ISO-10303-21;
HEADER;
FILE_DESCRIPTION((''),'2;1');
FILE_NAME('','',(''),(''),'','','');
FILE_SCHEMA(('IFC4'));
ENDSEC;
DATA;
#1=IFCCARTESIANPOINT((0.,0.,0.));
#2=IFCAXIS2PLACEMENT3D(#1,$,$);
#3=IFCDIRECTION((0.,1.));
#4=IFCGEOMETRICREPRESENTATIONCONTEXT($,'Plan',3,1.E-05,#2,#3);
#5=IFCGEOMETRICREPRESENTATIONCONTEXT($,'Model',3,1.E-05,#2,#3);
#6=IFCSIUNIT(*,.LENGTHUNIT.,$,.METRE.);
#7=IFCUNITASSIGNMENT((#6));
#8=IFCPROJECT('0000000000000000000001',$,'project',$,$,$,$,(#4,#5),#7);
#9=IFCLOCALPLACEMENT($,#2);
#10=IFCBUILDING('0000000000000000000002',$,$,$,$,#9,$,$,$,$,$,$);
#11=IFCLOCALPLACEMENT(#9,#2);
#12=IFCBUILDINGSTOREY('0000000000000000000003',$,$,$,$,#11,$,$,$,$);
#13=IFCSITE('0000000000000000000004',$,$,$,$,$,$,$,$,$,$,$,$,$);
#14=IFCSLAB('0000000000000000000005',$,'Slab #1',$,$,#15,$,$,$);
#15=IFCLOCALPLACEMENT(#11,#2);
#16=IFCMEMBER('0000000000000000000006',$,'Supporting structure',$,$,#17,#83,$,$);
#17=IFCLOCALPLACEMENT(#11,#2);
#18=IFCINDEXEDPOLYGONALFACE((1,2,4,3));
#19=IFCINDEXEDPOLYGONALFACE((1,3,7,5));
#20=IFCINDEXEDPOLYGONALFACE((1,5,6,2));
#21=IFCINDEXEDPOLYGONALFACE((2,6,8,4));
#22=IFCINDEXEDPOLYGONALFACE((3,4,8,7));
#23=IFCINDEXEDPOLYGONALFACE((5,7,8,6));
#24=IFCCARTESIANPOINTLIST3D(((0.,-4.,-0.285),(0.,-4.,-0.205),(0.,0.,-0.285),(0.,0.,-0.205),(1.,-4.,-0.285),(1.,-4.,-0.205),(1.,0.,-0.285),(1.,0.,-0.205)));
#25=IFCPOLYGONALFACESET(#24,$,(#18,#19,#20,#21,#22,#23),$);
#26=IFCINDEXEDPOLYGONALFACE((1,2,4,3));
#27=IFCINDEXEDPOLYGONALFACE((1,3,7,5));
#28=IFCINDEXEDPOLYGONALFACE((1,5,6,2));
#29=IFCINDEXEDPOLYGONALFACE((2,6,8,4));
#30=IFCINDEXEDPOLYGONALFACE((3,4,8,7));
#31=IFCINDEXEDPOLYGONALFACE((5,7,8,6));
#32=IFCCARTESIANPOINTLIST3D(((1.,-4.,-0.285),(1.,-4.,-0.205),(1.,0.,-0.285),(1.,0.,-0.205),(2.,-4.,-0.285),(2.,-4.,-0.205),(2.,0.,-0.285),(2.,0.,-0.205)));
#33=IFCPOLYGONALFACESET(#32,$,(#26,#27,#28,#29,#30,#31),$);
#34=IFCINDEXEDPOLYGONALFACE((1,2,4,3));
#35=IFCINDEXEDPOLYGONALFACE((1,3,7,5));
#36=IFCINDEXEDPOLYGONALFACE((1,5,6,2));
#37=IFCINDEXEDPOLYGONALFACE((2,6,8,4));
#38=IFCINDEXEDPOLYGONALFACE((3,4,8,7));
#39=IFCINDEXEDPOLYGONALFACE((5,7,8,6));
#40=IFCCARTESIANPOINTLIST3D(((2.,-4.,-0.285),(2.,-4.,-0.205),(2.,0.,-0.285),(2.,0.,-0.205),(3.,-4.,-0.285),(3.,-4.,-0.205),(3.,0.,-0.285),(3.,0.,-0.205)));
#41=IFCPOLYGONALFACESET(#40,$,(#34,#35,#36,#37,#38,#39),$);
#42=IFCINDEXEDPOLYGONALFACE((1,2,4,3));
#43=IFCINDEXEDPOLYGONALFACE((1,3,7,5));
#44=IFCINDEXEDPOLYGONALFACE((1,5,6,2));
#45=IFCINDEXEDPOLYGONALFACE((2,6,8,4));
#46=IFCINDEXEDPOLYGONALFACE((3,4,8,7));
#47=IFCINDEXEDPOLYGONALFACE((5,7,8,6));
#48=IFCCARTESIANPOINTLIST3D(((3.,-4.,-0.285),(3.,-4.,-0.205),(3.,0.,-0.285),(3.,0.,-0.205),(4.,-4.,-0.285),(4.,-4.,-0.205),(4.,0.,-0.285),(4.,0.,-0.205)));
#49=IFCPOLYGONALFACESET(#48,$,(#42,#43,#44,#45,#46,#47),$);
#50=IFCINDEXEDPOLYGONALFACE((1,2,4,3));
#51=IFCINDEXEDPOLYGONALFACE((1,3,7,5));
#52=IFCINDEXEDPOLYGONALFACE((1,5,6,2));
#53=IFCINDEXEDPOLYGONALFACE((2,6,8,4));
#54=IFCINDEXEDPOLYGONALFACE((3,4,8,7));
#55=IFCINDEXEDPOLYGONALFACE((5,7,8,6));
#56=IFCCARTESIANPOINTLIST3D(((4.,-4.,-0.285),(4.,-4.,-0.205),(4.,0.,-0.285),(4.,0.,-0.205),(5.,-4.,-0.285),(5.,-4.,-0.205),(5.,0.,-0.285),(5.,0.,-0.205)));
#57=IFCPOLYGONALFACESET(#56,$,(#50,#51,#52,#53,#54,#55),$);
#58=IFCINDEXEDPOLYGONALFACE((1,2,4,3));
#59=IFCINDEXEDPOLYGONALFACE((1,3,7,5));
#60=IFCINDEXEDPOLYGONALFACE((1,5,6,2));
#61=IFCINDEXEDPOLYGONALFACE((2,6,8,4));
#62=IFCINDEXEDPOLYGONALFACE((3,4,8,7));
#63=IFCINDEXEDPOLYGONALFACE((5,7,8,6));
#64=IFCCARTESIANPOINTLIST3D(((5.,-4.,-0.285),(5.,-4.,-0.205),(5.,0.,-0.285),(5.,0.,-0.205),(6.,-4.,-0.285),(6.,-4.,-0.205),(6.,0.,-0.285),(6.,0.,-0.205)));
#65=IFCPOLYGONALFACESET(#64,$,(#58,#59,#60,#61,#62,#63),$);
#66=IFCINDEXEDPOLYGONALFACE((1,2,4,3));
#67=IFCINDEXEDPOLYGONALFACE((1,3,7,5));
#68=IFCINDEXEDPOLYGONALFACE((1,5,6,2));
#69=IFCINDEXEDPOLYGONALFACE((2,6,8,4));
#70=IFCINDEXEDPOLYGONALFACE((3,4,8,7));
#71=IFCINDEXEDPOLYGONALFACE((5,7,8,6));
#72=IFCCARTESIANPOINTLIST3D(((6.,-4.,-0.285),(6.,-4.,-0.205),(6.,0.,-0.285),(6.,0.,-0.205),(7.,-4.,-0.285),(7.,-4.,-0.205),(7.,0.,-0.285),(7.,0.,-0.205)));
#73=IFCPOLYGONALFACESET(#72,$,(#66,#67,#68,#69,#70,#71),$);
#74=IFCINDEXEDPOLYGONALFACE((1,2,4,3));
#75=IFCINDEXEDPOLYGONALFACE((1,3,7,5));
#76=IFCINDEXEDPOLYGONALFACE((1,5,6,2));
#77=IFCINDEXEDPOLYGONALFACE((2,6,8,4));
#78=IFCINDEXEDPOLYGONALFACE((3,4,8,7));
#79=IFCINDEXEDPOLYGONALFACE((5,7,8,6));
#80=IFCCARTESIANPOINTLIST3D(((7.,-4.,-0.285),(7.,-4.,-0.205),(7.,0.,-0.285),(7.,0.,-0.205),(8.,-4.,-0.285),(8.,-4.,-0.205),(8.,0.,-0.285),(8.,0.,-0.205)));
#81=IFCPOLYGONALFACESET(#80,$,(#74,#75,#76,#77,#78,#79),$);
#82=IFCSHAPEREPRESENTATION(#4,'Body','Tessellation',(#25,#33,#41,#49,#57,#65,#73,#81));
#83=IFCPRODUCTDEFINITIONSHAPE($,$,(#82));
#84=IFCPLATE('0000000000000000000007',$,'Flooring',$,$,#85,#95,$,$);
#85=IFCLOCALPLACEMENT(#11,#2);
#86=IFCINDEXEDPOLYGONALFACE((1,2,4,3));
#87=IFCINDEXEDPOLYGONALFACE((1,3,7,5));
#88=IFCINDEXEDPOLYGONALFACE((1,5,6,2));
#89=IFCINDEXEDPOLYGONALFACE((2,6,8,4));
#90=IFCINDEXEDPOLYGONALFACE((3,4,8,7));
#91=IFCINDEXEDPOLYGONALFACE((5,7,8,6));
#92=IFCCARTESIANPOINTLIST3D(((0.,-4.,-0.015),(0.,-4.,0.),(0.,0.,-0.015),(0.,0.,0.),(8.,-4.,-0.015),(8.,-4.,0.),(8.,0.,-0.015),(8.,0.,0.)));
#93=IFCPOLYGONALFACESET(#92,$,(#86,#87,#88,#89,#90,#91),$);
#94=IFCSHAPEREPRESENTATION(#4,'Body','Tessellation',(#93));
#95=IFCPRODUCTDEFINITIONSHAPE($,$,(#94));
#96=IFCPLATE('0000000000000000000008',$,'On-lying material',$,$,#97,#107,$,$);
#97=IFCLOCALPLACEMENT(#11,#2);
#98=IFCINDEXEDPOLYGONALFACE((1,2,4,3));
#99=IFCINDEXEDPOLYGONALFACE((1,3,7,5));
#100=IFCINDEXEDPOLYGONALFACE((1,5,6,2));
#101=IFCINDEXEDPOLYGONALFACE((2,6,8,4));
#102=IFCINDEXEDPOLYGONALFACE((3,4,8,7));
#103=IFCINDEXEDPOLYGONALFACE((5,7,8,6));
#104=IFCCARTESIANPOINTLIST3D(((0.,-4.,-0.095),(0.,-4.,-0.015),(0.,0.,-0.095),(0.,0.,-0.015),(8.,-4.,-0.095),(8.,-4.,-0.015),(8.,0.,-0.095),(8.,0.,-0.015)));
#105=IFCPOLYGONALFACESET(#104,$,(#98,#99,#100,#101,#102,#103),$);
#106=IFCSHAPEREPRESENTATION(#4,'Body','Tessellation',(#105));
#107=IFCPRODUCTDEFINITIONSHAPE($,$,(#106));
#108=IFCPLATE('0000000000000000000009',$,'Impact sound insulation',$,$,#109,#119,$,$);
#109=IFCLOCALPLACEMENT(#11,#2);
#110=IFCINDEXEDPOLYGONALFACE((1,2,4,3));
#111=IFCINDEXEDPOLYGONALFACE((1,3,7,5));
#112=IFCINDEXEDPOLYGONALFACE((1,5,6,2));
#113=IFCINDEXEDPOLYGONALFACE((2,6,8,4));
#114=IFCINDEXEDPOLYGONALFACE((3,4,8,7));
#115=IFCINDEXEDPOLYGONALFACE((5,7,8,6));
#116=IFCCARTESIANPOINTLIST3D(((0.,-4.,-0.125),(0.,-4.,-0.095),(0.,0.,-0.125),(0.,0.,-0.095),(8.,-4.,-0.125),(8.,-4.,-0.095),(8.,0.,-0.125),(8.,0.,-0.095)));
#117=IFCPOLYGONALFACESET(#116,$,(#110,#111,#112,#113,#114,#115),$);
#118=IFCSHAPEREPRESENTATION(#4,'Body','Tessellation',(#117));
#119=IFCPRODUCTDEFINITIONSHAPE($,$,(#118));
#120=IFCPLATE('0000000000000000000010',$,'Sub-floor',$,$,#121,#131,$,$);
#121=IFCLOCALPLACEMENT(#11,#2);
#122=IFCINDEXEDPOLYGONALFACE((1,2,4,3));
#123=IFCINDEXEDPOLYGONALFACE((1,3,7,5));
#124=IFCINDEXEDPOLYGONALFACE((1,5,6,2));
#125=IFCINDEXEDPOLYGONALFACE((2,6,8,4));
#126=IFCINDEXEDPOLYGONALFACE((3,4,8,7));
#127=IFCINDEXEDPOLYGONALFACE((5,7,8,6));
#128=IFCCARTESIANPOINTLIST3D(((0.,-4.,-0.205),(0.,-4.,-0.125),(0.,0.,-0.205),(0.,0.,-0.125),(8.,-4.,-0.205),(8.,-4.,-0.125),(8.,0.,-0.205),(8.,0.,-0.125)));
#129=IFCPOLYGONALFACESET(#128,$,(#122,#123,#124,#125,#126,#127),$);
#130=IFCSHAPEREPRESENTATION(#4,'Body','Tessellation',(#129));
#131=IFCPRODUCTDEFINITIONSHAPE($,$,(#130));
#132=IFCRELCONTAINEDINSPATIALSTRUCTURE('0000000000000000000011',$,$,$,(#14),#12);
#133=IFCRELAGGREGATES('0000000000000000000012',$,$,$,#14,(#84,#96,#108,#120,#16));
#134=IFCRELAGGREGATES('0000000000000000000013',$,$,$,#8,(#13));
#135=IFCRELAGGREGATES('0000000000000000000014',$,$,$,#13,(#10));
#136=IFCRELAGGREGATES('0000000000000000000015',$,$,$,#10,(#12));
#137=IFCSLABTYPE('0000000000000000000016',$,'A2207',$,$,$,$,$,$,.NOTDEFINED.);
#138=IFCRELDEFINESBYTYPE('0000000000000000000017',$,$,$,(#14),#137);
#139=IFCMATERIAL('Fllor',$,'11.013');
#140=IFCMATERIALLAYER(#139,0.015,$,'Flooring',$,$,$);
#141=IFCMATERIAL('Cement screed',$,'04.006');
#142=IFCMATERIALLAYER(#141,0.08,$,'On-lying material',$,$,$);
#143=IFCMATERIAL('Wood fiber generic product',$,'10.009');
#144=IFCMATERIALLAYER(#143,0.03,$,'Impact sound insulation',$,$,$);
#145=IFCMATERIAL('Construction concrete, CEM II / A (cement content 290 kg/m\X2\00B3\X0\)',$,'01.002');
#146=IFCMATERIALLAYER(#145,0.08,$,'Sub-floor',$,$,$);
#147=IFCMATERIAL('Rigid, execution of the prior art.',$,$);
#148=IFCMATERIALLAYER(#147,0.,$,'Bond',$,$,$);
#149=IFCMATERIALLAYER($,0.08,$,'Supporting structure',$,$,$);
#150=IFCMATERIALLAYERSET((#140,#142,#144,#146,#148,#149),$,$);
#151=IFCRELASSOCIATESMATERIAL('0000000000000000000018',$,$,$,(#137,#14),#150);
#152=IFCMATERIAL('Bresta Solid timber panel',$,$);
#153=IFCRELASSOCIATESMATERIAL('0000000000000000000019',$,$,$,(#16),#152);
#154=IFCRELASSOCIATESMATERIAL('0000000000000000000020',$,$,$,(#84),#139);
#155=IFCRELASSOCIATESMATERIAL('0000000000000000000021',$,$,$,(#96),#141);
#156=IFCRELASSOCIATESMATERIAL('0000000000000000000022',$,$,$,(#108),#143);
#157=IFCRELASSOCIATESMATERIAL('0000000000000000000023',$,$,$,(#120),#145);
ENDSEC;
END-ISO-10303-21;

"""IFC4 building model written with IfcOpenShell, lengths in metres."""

from ifc_helpers import new_model, si_unit, direction, frame, frame_2d, origin, origin_with_axes, place, context, project, spatial, rectangle, extrude, material, layer, layer_set, type_object, element, aggregate, save


model = new_model("IFC4")

# Units and contexts
plan_context = context("Plan", 3, precision=1e-05, world=origin(), true_north=direction((0.0, 1.0)))
model_context = context("Model", 3, precision=1e-05, world=origin(), true_north=direction((0.0, 1.0)))
ifc_project = project(units=[si_unit("LENGTHUNIT", "METRE")], contexts=[plan_context, model_context])

# Site, building, storey
site = spatial("IfcSite", under=ifc_project)
building_placement = place(None, origin())
building = spatial("IfcBuilding", under=site, at=building_placement)
storey_placement = place(building_placement, origin())
storey = spatial("IfcBuildingStorey", under=building, at=storey_placement)

# Slab, member, plates
ifc_material_1 = material(Name="Fllor", Category="11.013")
ifc_layer_1 = layer(ifc_material_1, 0.015, Name="Flooring")
ifc_material_2 = material(Name="Cement screed", Category="04.006")
ifc_layer_2 = layer(ifc_material_2, 0.08, Name="On-lying material")
ifc_material_3 = material(Name="Wood fiber generic product", Category="10.009")
ifc_layer_3 = layer(ifc_material_3, 0.03, Name="Impact sound insulation")
ifc_material_4 = material(Name="Construction concrete, CEM II / A (cement content 290 kg/m³)", Category="01.002")
ifc_layer_4 = layer(ifc_material_4, 0.08, Name="Sub-floor")
ifc_material_5 = material(Name="Rigid, execution of the prior art.")
ifc_layer_5 = layer(ifc_material_5, 0.0, Name="Bond")
ifc_layer_6 = layer(None, 0.08, Name="Supporting structure")
ifc_layer_set = layer_set([ifc_layer_1, ifc_layer_2, ifc_layer_3, ifc_layer_4, ifc_layer_5, ifc_layer_6])
slab_type = type_object("IfcSlabType", Name="A2207", PredefinedType="NOTDEFINED", material=ifc_layer_set)
slab_placement = place(None, frame((0.0, 0.0, 0.0), z_axis=(0.0, 0.0, -1.0), x_axis=(1.0, 0.0, 0.0)))
slab = element("IfcSlab", 1, at=slab_placement, inside=storey, type_object=slab_type, material=ifc_layer_set, Name="Slab #1")
ifc_material_6 = material(Name="Bresta Solid timber panel")
member_placement = place(slab_placement, origin())
member = element("IfcMember", 2, at=member_placement, material=ifc_material_6, Name="Supporting structure", context=plan_context, shape_type="SweptSolid", body=[
    extrude(rectangle(XDim=1.0, YDim=0.08, at=frame_2d((0.5, 0.04), x_axis=(1.0, 0.0))), frame((0.0, 4.0, 0.205), z_axis=(0.0, -1.0, 0.0), x_axis=(1.0, 0.0, 0.0)), (0.0, 0.0, 1.0), 4.0),
    extrude(rectangle(XDim=1.0, YDim=0.08, at=frame_2d((0.5, 0.04), x_axis=(1.0, 0.0))), frame((1.0, 4.0, 0.205), z_axis=(0.0, -1.0, 0.0), x_axis=(1.0, 0.0, 0.0)), (0.0, 0.0, 1.0), 4.0),
    extrude(rectangle(XDim=1.0, YDim=0.08, at=frame_2d((0.5, 0.04), x_axis=(1.0, 0.0))), frame((2.0, 4.0, 0.205), z_axis=(0.0, -1.0, 0.0), x_axis=(1.0, 0.0, 0.0)), (0.0, 0.0, 1.0), 4.0),
    extrude(rectangle(XDim=1.0, YDim=0.08, at=frame_2d((0.5, 0.04), x_axis=(1.0, 0.0))), frame((3.0, 4.0, 0.205), z_axis=(0.0, -1.0, 0.0), x_axis=(1.0, 0.0, 0.0)), (0.0, 0.0, 1.0), 4.0),
    extrude(rectangle(XDim=1.0, YDim=0.08, at=frame_2d((0.5, 0.04), x_axis=(1.0, 0.0))), frame((4.0, 4.0, 0.205), z_axis=(0.0, -1.0, 0.0), x_axis=(1.0, 0.0, 0.0)), (0.0, 0.0, 1.0), 4.0),
    extrude(rectangle(XDim=1.0, YDim=0.08, at=frame_2d((0.5, 0.04), x_axis=(1.0, 0.0))), frame((5.0, 4.0, 0.205), z_axis=(0.0, -1.0, 0.0), x_axis=(1.0, 0.0, 0.0)), (0.0, 0.0, 1.0), 4.0),
    extrude(rectangle(XDim=1.0, YDim=0.08, at=frame_2d((0.5, 0.04), x_axis=(1.0, 0.0))), frame((6.0, 4.0, 0.205), z_axis=(0.0, -1.0, 0.0), x_axis=(1.0, 0.0, 0.0)), (0.0, 0.0, 1.0), 4.0),
    extrude(rectangle(XDim=1.0, YDim=0.08, at=frame_2d((0.5, 0.04), x_axis=(1.0, 0.0))), frame((7.0, 4.0, 0.205), z_axis=(0.0, -1.0, 0.0), x_axis=(1.0, 0.0, 0.0)), (0.0, 0.0, 1.0), 4.0),
])
plate_1_placement = place(slab_placement, origin())
plate_1 = element("IfcPlate", 3, at=plate_1_placement, material=ifc_material_1, Name="Flooring", context=plan_context, shape_type="SweptSolid", body=[
    extrude(rectangle(XDim=8.0, YDim=4.0, at=frame_2d((4.0, 2.0), x_axis=(1.0, 0.0))), origin_with_axes(), (0.0, 0.0, 1.0), 0.015),
])
plate_2_placement = place(slab_placement, origin())
plate_2 = element("IfcPlate", 4, at=plate_2_placement, material=ifc_material_2, Name="On-lying material", context=plan_context, shape_type="SweptSolid", body=[
    extrude(rectangle(XDim=8.0, YDim=4.0, at=frame_2d((4.0, 2.0), x_axis=(1.0, 0.0))), frame((0.0, 0.0, 0.015), z_axis=(0.0, 0.0, 1.0), x_axis=(1.0, 0.0, 0.0)), (0.0, 0.0, 1.0), 0.08),
])
plate_3_placement = place(slab_placement, origin())
plate_3 = element("IfcPlate", 5, at=plate_3_placement, material=ifc_material_3, Name="Impact sound insulation", context=plan_context, shape_type="SweptSolid", body=[
    extrude(rectangle(XDim=8.0, YDim=4.0, at=frame_2d((4.0, 2.0), x_axis=(1.0, 0.0))), frame((0.0, 0.0, 0.095), z_axis=(0.0, 0.0, 1.0), x_axis=(1.0, 0.0, 0.0)), (0.0, 0.0, 1.0), 0.03),
])
plate_4_placement = place(slab_placement, origin())
plate_4 = element("IfcPlate", 6, at=plate_4_placement, material=ifc_material_4, Name="Sub-floor", context=plan_context, shape_type="SweptSolid", body=[
    extrude(rectangle(XDim=8.0, YDim=4.0, at=frame_2d((4.0, 2.0), x_axis=(1.0, 0.0))), frame((0.0, 0.0, 0.125), z_axis=(0.0, 0.0, 1.0), x_axis=(1.0, 0.0, 0.0)), (0.0, 0.0, 1.0), 0.08),
])
aggregate(slab, [plate_1, plate_2, plate_3, plate_4, member])

save(model, "model.ifc")
